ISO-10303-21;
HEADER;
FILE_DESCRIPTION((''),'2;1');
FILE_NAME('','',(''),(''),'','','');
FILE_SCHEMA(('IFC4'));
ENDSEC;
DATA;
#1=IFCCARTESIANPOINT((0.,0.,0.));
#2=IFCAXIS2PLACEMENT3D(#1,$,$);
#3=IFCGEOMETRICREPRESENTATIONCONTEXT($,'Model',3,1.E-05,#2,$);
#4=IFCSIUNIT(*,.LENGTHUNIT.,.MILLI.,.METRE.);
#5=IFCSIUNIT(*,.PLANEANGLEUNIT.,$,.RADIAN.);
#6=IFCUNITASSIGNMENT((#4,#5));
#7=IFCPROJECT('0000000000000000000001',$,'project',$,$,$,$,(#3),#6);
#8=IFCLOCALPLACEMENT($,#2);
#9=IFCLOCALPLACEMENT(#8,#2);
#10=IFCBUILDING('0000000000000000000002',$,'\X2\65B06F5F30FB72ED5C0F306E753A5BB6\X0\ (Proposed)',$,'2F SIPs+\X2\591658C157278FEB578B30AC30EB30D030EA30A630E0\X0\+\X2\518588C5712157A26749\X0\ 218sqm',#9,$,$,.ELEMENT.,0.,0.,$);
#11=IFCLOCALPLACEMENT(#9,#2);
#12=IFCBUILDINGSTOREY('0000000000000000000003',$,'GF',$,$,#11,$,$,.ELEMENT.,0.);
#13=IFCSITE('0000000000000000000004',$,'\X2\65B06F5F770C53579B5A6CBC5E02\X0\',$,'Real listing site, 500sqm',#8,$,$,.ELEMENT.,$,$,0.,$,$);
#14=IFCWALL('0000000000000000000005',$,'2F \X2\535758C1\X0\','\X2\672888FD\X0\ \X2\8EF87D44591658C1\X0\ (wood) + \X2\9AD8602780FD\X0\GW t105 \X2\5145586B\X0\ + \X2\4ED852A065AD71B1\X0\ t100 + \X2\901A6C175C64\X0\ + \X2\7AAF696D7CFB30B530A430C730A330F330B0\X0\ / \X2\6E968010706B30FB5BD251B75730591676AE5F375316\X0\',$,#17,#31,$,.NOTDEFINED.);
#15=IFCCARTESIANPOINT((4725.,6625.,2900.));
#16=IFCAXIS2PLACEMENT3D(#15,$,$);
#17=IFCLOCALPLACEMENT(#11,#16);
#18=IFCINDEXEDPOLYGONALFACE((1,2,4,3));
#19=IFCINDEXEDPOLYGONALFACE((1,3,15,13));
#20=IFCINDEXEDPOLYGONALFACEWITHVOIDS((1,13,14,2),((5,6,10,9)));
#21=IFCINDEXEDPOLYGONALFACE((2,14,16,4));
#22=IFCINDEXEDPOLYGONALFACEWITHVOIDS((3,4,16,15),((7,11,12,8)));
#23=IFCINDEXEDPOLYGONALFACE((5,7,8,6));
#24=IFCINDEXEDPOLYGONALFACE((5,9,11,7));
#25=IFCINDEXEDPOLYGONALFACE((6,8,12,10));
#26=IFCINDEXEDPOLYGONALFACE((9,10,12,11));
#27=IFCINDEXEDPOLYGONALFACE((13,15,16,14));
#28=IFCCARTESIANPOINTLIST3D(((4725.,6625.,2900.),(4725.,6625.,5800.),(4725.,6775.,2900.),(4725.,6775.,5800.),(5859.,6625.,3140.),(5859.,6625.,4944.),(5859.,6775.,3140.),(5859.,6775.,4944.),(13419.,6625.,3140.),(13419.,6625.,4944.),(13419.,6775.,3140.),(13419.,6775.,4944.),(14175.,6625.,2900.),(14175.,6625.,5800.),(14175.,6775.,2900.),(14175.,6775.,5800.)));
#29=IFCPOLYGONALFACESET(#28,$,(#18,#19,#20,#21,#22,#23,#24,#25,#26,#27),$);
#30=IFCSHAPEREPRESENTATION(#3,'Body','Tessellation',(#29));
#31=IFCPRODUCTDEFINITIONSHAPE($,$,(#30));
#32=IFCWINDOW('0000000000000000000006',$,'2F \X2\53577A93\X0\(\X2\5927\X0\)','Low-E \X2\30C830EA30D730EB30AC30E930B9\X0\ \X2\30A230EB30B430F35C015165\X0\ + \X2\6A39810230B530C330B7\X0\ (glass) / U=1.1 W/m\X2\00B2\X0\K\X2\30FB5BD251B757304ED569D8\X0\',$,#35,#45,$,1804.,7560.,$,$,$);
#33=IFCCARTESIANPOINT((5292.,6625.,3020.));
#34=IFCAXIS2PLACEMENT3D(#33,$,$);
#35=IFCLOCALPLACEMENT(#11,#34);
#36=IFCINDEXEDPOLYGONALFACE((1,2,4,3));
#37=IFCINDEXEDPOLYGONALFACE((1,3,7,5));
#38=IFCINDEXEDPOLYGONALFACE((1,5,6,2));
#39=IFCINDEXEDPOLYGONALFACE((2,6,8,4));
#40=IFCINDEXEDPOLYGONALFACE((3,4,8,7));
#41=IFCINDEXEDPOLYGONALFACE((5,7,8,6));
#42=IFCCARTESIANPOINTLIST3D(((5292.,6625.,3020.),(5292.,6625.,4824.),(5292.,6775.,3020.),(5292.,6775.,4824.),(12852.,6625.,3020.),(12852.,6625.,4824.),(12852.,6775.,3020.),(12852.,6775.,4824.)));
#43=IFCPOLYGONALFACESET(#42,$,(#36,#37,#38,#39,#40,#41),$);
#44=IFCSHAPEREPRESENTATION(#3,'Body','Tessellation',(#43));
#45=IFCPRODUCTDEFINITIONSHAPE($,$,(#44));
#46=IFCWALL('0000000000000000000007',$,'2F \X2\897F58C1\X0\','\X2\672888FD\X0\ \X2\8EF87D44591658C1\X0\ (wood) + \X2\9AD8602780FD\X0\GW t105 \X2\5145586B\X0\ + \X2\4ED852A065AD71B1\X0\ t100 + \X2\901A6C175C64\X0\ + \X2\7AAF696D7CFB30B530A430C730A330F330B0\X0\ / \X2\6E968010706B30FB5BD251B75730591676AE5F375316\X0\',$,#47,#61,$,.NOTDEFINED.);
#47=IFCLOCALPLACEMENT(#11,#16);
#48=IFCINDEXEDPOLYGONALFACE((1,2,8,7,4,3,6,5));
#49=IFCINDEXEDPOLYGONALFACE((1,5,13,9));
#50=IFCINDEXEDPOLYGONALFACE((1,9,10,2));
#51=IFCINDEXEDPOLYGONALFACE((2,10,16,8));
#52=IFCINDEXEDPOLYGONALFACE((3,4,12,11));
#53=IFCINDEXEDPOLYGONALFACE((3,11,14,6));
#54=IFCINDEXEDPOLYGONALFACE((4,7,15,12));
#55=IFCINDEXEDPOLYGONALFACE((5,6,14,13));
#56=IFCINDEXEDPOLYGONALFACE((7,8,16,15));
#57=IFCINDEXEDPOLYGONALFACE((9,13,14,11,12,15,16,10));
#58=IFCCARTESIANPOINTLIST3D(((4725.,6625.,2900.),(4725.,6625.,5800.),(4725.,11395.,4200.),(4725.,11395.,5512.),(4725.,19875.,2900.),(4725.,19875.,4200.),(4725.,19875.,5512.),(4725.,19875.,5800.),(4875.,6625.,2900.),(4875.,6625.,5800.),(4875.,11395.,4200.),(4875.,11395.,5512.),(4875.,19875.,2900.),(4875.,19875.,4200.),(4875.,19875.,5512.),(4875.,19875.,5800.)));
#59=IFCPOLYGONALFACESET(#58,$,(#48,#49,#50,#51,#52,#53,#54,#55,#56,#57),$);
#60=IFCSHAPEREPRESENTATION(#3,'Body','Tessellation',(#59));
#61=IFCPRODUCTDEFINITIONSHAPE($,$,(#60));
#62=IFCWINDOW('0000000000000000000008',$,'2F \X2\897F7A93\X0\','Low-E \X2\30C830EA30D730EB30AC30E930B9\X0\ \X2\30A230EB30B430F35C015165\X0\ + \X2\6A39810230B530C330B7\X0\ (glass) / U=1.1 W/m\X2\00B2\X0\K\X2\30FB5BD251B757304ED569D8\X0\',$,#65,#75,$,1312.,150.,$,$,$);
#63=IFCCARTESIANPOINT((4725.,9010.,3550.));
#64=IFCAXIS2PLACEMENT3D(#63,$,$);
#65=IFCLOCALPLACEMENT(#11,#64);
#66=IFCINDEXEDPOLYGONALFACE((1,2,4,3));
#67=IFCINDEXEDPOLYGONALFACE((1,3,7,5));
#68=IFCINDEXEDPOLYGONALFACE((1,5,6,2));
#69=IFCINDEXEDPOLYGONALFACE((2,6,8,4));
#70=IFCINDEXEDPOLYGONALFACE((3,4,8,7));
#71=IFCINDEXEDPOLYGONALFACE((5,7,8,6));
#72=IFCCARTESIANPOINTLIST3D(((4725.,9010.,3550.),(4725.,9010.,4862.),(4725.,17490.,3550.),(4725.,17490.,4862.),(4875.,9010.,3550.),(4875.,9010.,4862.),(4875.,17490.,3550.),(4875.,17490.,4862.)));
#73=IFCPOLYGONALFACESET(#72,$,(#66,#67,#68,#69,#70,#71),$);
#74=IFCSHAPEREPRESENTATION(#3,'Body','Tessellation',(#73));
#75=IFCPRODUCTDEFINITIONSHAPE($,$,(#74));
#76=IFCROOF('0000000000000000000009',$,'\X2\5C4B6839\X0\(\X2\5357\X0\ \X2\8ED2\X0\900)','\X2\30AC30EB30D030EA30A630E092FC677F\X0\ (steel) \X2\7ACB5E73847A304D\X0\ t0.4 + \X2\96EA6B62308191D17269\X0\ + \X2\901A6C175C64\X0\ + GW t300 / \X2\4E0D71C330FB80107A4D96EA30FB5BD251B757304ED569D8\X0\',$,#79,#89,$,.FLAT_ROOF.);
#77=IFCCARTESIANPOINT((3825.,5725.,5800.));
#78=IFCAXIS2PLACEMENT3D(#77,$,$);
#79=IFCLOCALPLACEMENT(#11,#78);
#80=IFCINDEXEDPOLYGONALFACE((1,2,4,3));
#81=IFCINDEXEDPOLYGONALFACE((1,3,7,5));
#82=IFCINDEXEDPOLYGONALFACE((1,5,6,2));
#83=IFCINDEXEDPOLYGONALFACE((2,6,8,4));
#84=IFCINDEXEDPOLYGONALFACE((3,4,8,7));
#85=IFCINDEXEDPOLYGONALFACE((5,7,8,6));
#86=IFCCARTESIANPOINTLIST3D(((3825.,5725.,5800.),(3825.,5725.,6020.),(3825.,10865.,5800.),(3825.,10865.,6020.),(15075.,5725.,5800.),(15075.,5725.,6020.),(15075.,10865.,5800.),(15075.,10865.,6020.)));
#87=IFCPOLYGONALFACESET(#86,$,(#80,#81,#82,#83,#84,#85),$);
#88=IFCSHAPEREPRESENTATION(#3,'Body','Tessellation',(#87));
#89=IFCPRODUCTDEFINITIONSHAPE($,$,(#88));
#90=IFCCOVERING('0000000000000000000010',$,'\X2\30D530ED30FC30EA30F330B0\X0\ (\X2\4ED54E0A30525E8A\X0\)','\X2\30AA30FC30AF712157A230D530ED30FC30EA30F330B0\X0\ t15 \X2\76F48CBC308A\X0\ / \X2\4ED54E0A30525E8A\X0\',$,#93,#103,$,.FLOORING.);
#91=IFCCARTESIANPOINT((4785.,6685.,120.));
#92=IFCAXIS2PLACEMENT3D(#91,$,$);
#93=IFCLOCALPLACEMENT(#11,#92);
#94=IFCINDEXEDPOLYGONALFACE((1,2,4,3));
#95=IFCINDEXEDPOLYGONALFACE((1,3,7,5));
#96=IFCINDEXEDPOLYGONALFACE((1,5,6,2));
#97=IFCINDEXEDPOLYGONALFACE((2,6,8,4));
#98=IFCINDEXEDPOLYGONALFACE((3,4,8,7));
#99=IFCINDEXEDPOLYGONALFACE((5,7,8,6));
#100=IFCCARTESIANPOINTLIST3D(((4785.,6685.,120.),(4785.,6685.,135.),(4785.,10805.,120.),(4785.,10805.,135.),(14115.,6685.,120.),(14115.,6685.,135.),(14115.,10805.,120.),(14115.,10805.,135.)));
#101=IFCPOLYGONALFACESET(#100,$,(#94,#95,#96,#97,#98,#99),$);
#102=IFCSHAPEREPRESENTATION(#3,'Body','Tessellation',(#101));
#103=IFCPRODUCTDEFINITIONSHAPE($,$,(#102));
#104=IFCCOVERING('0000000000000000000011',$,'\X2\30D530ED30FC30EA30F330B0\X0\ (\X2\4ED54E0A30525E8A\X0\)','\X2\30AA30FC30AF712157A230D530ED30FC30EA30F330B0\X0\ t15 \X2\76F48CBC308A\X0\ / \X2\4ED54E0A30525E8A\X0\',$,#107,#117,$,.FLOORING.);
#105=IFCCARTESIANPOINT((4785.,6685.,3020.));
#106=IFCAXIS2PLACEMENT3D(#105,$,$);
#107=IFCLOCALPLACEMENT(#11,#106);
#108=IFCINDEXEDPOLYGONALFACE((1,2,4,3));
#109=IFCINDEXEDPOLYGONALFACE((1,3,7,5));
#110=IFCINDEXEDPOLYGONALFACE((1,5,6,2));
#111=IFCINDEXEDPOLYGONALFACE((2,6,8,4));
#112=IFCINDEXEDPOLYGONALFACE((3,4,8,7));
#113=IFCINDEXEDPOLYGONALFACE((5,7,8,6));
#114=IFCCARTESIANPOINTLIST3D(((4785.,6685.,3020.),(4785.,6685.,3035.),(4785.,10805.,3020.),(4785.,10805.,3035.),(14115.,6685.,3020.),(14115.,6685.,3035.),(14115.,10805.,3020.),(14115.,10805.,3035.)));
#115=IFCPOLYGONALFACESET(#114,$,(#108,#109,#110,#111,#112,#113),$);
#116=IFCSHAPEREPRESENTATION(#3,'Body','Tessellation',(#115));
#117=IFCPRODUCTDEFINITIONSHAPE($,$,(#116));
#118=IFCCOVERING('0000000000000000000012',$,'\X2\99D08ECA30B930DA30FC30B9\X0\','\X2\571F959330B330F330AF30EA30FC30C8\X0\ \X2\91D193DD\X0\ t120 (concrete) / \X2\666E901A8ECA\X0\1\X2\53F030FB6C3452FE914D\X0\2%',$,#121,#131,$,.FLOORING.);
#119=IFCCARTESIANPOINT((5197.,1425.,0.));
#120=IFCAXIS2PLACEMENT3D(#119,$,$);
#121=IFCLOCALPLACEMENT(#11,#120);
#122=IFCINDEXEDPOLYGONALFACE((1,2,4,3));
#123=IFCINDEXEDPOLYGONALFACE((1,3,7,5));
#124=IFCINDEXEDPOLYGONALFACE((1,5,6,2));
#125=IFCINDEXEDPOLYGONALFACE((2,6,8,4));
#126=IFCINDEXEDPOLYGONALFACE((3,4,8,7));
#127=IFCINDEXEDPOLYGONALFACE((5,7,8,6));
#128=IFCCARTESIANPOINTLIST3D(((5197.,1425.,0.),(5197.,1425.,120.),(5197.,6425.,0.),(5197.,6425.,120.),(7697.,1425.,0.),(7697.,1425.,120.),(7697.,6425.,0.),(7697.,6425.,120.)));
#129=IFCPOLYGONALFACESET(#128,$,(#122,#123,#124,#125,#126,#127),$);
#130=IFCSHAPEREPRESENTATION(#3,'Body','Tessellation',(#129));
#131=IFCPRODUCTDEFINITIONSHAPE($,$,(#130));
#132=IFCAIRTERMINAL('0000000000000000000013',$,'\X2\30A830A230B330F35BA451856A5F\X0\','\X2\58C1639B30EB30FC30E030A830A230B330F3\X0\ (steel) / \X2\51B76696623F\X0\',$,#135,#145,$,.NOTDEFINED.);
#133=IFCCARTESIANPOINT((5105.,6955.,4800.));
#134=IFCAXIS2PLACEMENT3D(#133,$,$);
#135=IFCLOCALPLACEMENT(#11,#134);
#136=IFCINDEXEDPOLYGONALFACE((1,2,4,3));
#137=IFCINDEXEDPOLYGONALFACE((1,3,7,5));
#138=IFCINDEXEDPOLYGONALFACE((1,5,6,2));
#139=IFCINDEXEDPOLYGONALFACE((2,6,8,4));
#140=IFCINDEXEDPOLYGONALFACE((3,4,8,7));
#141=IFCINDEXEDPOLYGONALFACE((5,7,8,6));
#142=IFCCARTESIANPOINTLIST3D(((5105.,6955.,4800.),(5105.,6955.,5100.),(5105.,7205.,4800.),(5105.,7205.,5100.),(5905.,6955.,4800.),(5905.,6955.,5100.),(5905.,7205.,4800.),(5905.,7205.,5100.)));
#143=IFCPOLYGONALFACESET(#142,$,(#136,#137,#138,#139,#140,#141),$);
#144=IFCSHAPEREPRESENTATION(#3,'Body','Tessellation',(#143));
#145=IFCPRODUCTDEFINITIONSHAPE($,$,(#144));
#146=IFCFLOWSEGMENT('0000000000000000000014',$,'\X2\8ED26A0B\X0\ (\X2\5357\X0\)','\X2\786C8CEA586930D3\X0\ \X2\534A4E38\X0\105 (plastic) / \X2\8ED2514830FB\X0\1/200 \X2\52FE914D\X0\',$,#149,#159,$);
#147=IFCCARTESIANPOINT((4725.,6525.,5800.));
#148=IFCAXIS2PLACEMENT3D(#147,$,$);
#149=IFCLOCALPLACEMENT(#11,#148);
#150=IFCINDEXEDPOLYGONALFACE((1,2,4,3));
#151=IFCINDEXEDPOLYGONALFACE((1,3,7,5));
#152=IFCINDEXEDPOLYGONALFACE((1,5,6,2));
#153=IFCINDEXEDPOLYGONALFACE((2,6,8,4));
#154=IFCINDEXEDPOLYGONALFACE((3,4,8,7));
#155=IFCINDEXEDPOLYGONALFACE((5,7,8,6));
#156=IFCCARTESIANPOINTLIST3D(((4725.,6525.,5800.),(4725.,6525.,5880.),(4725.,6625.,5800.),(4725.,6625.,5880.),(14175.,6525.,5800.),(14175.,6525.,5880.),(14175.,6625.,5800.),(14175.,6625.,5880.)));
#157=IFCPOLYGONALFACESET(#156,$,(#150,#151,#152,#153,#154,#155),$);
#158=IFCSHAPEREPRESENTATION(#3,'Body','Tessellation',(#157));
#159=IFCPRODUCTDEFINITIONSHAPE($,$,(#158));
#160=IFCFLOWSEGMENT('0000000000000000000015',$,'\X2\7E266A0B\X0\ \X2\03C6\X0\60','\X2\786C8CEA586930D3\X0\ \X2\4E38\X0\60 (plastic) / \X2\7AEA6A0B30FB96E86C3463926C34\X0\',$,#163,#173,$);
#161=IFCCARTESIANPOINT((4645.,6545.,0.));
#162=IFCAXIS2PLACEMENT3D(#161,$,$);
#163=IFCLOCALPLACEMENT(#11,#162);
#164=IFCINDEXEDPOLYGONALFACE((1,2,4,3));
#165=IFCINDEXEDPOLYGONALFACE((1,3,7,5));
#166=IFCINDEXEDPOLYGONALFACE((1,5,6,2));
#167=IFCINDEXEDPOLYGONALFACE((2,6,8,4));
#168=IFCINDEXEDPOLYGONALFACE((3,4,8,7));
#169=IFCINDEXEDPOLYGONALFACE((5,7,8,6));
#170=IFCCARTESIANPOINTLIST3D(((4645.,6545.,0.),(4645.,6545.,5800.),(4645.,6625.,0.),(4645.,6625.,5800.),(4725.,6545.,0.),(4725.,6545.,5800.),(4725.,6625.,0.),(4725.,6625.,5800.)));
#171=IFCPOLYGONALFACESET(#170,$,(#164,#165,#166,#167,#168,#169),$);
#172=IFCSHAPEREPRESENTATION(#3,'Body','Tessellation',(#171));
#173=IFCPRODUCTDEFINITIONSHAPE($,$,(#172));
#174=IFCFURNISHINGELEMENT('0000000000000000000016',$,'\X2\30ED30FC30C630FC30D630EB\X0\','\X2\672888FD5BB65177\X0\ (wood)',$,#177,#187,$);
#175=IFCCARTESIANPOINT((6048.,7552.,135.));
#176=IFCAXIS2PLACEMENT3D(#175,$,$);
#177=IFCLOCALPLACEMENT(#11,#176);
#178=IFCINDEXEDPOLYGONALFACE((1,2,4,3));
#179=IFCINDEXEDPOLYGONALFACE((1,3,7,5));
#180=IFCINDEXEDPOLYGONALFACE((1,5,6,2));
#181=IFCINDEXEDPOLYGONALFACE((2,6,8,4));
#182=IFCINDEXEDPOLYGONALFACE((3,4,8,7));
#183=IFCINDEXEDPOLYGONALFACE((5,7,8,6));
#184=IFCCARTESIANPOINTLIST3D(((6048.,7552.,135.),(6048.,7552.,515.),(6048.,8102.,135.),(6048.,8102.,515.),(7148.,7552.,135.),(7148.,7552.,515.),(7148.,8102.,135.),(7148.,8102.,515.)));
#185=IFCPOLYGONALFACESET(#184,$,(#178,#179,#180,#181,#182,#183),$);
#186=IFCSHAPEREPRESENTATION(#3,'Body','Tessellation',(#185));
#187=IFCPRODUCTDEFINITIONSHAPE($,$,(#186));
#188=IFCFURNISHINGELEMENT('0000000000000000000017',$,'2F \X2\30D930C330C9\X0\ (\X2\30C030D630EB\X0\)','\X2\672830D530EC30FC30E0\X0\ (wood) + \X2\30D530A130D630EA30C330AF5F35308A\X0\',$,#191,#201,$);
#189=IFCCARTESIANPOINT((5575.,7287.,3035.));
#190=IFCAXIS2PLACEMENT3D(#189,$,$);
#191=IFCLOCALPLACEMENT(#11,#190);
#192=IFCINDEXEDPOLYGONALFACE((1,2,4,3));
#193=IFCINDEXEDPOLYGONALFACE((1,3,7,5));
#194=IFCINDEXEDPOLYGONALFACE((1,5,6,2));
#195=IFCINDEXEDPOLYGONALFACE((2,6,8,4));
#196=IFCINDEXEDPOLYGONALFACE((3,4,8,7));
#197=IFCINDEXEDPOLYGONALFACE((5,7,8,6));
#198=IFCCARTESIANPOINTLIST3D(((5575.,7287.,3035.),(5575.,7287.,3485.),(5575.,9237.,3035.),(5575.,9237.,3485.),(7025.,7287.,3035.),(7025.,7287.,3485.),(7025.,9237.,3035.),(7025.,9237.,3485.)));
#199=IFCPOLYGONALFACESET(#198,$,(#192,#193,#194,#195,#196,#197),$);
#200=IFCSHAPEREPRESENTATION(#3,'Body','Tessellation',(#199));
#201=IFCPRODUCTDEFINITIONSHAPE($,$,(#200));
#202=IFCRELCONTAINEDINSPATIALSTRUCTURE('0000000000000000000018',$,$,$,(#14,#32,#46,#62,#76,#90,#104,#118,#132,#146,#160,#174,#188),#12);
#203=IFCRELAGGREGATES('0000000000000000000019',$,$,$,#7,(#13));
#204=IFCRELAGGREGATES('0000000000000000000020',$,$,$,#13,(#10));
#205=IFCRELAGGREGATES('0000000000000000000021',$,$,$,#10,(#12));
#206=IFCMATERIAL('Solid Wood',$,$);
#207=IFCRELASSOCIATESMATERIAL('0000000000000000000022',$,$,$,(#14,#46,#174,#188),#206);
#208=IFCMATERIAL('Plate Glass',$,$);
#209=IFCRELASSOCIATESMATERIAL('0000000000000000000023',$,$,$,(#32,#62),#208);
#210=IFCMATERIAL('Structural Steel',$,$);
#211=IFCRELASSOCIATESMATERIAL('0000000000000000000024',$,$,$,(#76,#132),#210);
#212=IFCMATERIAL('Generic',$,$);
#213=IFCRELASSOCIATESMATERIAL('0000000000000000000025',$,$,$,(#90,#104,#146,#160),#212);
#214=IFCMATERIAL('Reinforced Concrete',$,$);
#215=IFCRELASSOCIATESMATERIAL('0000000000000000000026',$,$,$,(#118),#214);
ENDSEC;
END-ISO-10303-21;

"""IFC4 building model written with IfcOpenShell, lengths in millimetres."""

from ifc_helpers import new_model, si_unit, frame, frame_2d, origin, place, context, project, spatial, rectangle, extrude, material, element, fill, save


model = new_model("IFC4")

# Units and contexts
model_context = context("Model", 3, precision=1e-05, world=origin())
ifc_project = project(units=[si_unit("LENGTHUNIT", "METRE", prefix="MILLI"), si_unit("PLANEANGLEUNIT", "RADIAN")], contexts=[model_context])

# Site, building, storey
site_placement = place(None, origin())
site = spatial("IfcSite", under=ifc_project, at=site_placement, Name="新潟県南魚沼市", ObjectType="Real listing site, 500sqm", CompositionType="ELEMENT", RefElevation=0.0)
building_placement = place(site_placement, origin())
building = spatial("IfcBuilding", under=site, at=building_placement, Name="新潟・狭小の町家 (Proposed)", ObjectType="2F SIPs+外壁圧迫型ガルバリウム+内装無垢杉 218sqm", CompositionType="ELEMENT", ElevationOfRefHeight=0.0, ElevationOfTerrain=0.0)
storey_placement = place(building_placement, origin())
storey = spatial("IfcBuildingStorey", under=building, at=storey_placement, Name="GF", CompositionType="ELEMENT", Elevation=0.0)

# Shared definitions
ifc_material_1 = material(Name="Solid Wood")

# Shared definitions
ifc_material_2 = material(Name="Reinforced Concrete")

# Shared definitions
ifc_material_3 = material(Name="Plate Glass")

# Walls, openings, windows
wall_1_placement = place(storey_placement, frame((4725.0, 6625.0, 2900.0)))
wall_1 = element("IfcWall", 1, at=wall_1_placement, inside=storey, material=ifc_material_1, Name="2F 南壁", Description="木製 軸組外壁 (wood) + 高性能GW t105 充填 + 付加断熱 t100 + 通気層 + 窯業系サイディング / 準耐火・寒冷地外皮強化", PredefinedType="NOTDEFINED", context=model_context, shape_type="SweptSolid", body=[
    extrude(rectangle(XDim=9450.0, YDim=150.0, at=frame_2d((4725.0, 75.0))), frame((4725.0, 6625.0, 2900.0)), (0.0, 0.0, 1.0), 2900.0),
])
opening_1_placement = place(storey_placement, frame((5292.0, 6625.0, 3020.0)))
opening_1 = element("IfcOpeningElement", 2, at=opening_1_placement, cuts=wall_1, PredefinedType="NOTDEFINED", context=model_context, shape_type="SweptSolid", body=[
    extrude(rectangle(XDim=7560.0, YDim=150.0, at=frame_2d((3780.0, 75.0))), frame((5292.0, 6625.0, 3020.0)), (0.0, 0.0, 1.0), 1804.0),
])
window_1_placement = place(storey_placement, frame((5292.0, 6625.0, 3020.0)))
window_1 = element("IfcWindow", 3, at=window_1_placement, inside=storey, material=ifc_material_3, Name="2F 南窓(大)", Description="Low-E トリプルガラス アルゴン封入 + 樹脂サッシ (glass) / U=1.1 W/m²K・寒冷地仕様", OverallHeight=1804.0, OverallWidth=7560.0, context=model_context, shape_type="SweptSolid", body=[
    extrude(rectangle(XDim=7560.0, YDim=150.0, at=frame_2d((3780.0, 75.0))), frame((5292.0, 6625.0, 3020.0)), (0.0, 0.0, 1.0), 1804.0),
])
fill(opening_1, window_1)
wall_2_placement = place(storey_placement, frame((4725.0, 6625.0, 2900.0)))
wall_2 = element("IfcWall", 4, at=wall_2_placement, inside=storey, material=ifc_material_1, Name="2F 西壁", Description="木製 軸組外壁 (wood) + 高性能GW t105 充填 + 付加断熱 t100 + 通気層 + 窯業系サイディング / 準耐火・寒冷地外皮強化", PredefinedType="NOTDEFINED", context=model_context, shape_type="SweptSolid", body=[
    extrude(rectangle(XDim=150.0, YDim=13250.0, at=frame_2d((75.0, 6625.0))), frame((4725.0, 6625.0, 2900.0)), (0.0, 0.0, 1.0), 2900.0),
])
opening_2_placement = place(storey_placement, frame((4725.0, 9010.0, 3550.0)))
opening_2 = element("IfcOpeningElement", 5, at=opening_2_placement, cuts=wall_2, PredefinedType="NOTDEFINED", context=model_context, shape_type="SweptSolid", body=[
    extrude(rectangle(XDim=150.0, YDim=8480.0, at=frame_2d((75.0, 4240.0))), frame((4725.0, 9010.0, 3550.0)), (0.0, 0.0, 1.0), 1312.0),
])
window_2_placement = place(storey_placement, frame((4725.0, 9010.0, 3550.0)))
window_2 = element("IfcWindow", 6, at=window_2_placement, inside=storey, material=ifc_material_3, Name="2F 西窓", Description="Low-E トリプルガラス アルゴン封入 + 樹脂サッシ (glass) / U=1.1 W/m²K・寒冷地仕様", OverallHeight=1312.0, OverallWidth=150.0, context=model_context, shape_type="SweptSolid", body=[
    extrude(rectangle(XDim=150.0, YDim=8480.0, at=frame_2d((75.0, 4240.0))), frame((4725.0, 9010.0, 3550.0)), (0.0, 0.0, 1.0), 1312.0),
])
fill(opening_2, window_2)

# Roof
ifc_material_4 = material(Name="Structural Steel")
for number, where, name in (
    (7, (3825.0, 5725.0, 5800.0), "屋根(南 軒900)"),
):
    element("IfcRoof", number, at=place(storey_placement, frame(where)), inside=storey, material=ifc_material_4, Name=name, Description="ガルバリウム鋼板 (steel) 立平葺き t0.4 + 雪止め金物 + 通気層 + GW t300 / 不燃・耐積雪・寒冷地仕様", PredefinedType="FLAT_ROOF", context=model_context, shape_type="SweptSolid", body=[
        extrude(rectangle(XDim=11250.0, YDim=5140.0, at=frame_2d((5625.0, 2570.0))), frame((3825.0, 5725.0, 5800.0)), (0.0, 0.0, 1.0), 220.0),
    ])

# Coverings
ifc_material_5 = material(Name="Generic")
covering_1_placement = place(storey_placement, frame((4785.0, 6685.0, 120.0)))
element("IfcCovering", 8, at=covering_1_placement, inside=storey, material=ifc_material_5, Name="フローリング (仕上げ床)", Description="オーク無垢フローリング t15 直貼り / 仕上げ床", PredefinedType="FLOORING", context=model_context, shape_type="SweptSolid", body=[
    extrude(rectangle(XDim=9330.0, YDim=4120.0, at=frame_2d((4665.0, 2060.0))), frame((4785.0, 6685.0, 120.0)), (0.0, 0.0, 1.0), 15.0),
])
covering_2_placement = place(storey_placement, frame((4785.0, 6685.0, 3020.0)))
element("IfcCovering", 9, at=covering_2_placement, inside=storey, material=ifc_material_5, Name="フローリング (仕上げ床)", Description="オーク無垢フローリング t15 直貼り / 仕上げ床", PredefinedType="FLOORING", context=model_context, shape_type="SweptSolid", body=[
    extrude(rectangle(XDim=9330.0, YDim=4120.0, at=frame_2d((4665.0, 2060.0))), frame((4785.0, 6685.0, 3020.0)), (0.0, 0.0, 1.0), 15.0),
])
covering_3_placement = place(storey_placement, frame((5197.0, 1425.0, 0.0)))
element("IfcCovering", 10, at=covering_3_placement, inside=storey, material=ifc_material_2, Name="駐車スペース", Description="土間コンクリート 金鏝 t120 (concrete) / 普通車1台・水勾配2%", PredefinedType="FLOORING", context=model_context, shape_type="SweptSolid", body=[
    extrude(rectangle(XDim=2500.0, YDim=5000.0, at=frame_2d((1250.0, 2500.0))), frame((5197.0, 1425.0, 0.0)), (0.0, 0.0, 1.0), 120.0),
])

# Air terminal
air_terminal_placement = place(storey_placement, frame((5105.0, 6955.0, 4800.0)))
element("IfcAirTerminal", 11, at=air_terminal_placement, inside=storey, material=ifc_material_4, Name="エアコン室内機", Description="壁掛ルームエアコン (steel) / 冷暖房", PredefinedType="NOTDEFINED", context=model_context, shape_type="SweptSolid", body=[
    extrude(rectangle(XDim=800.0, YDim=250.0, at=frame_2d((400.0, 125.0))), frame((5105.0, 6955.0, 4800.0)), (0.0, 0.0, 1.0), 300.0),
])

# Flow segments
flow_segment_1_placement = place(storey_placement, frame((4725.0, 6525.0, 5800.0)))
element("IfcFlowSegment", 12, at=flow_segment_1_placement, inside=storey, material=ifc_material_5, Name="軒樋 (南)", Description="硬質塩ビ 半丸105 (plastic) / 軒先・1/200 勾配", context=model_context, shape_type="SweptSolid", body=[
    extrude(rectangle(XDim=9450.0, YDim=100.0, at=frame_2d((4725.0, 50.0))), frame((4725.0, 6525.0, 5800.0)), (0.0, 0.0, 1.0), 80.0),
])
flow_segment_2_placement = place(storey_placement, frame((4645.0, 6545.0, 0.0)))
element("IfcFlowSegment", 13, at=flow_segment_2_placement, inside=storey, material=ifc_material_5, Name="縦樋 φ60", Description="硬質塩ビ 丸60 (plastic) / 竪樋・雨水排水", context=model_context, shape_type="SweptSolid", body=[
    extrude(rectangle(XDim=80.0, YDim=80.0, at=frame_2d((40.0, 40.0))), frame((4645.0, 6545.0, 0.0)), (0.0, 0.0, 1.0), 5800.0),
])

# Furnishing elements
furnishing_1_placement = place(storey_placement, frame((6048.0, 7552.0, 135.0)))
element("IfcFurnishingElement", 14, at=furnishing_1_placement, inside=storey, material=ifc_material_1, Name="ローテーブル", Description="木製家具 (wood)", context=model_context, shape_type="SweptSolid", body=[
    extrude(rectangle(XDim=1100.0, YDim=550.0, at=frame_2d((550.0, 275.0))), frame((6048.0, 7552.0, 135.0)), (0.0, 0.0, 1.0), 380.0),
])
furnishing_2_placement = place(storey_placement, frame((5575.0, 7287.0, 3035.0)))
element("IfcFurnishingElement", 15, at=furnishing_2_placement, inside=storey, material=ifc_material_1, Name="2F ベッド (ダブル)", Description="木フレーム (wood) + ファブリック張り", context=model_context, shape_type="SweptSolid", body=[
    extrude(rectangle(XDim=1450.0, YDim=1950.0, at=frame_2d((725.0, 975.0))), frame((5575.0, 7287.0, 3035.0)), (0.0, 0.0, 1.0), 450.0),
])

save(model, "model.ifc")
